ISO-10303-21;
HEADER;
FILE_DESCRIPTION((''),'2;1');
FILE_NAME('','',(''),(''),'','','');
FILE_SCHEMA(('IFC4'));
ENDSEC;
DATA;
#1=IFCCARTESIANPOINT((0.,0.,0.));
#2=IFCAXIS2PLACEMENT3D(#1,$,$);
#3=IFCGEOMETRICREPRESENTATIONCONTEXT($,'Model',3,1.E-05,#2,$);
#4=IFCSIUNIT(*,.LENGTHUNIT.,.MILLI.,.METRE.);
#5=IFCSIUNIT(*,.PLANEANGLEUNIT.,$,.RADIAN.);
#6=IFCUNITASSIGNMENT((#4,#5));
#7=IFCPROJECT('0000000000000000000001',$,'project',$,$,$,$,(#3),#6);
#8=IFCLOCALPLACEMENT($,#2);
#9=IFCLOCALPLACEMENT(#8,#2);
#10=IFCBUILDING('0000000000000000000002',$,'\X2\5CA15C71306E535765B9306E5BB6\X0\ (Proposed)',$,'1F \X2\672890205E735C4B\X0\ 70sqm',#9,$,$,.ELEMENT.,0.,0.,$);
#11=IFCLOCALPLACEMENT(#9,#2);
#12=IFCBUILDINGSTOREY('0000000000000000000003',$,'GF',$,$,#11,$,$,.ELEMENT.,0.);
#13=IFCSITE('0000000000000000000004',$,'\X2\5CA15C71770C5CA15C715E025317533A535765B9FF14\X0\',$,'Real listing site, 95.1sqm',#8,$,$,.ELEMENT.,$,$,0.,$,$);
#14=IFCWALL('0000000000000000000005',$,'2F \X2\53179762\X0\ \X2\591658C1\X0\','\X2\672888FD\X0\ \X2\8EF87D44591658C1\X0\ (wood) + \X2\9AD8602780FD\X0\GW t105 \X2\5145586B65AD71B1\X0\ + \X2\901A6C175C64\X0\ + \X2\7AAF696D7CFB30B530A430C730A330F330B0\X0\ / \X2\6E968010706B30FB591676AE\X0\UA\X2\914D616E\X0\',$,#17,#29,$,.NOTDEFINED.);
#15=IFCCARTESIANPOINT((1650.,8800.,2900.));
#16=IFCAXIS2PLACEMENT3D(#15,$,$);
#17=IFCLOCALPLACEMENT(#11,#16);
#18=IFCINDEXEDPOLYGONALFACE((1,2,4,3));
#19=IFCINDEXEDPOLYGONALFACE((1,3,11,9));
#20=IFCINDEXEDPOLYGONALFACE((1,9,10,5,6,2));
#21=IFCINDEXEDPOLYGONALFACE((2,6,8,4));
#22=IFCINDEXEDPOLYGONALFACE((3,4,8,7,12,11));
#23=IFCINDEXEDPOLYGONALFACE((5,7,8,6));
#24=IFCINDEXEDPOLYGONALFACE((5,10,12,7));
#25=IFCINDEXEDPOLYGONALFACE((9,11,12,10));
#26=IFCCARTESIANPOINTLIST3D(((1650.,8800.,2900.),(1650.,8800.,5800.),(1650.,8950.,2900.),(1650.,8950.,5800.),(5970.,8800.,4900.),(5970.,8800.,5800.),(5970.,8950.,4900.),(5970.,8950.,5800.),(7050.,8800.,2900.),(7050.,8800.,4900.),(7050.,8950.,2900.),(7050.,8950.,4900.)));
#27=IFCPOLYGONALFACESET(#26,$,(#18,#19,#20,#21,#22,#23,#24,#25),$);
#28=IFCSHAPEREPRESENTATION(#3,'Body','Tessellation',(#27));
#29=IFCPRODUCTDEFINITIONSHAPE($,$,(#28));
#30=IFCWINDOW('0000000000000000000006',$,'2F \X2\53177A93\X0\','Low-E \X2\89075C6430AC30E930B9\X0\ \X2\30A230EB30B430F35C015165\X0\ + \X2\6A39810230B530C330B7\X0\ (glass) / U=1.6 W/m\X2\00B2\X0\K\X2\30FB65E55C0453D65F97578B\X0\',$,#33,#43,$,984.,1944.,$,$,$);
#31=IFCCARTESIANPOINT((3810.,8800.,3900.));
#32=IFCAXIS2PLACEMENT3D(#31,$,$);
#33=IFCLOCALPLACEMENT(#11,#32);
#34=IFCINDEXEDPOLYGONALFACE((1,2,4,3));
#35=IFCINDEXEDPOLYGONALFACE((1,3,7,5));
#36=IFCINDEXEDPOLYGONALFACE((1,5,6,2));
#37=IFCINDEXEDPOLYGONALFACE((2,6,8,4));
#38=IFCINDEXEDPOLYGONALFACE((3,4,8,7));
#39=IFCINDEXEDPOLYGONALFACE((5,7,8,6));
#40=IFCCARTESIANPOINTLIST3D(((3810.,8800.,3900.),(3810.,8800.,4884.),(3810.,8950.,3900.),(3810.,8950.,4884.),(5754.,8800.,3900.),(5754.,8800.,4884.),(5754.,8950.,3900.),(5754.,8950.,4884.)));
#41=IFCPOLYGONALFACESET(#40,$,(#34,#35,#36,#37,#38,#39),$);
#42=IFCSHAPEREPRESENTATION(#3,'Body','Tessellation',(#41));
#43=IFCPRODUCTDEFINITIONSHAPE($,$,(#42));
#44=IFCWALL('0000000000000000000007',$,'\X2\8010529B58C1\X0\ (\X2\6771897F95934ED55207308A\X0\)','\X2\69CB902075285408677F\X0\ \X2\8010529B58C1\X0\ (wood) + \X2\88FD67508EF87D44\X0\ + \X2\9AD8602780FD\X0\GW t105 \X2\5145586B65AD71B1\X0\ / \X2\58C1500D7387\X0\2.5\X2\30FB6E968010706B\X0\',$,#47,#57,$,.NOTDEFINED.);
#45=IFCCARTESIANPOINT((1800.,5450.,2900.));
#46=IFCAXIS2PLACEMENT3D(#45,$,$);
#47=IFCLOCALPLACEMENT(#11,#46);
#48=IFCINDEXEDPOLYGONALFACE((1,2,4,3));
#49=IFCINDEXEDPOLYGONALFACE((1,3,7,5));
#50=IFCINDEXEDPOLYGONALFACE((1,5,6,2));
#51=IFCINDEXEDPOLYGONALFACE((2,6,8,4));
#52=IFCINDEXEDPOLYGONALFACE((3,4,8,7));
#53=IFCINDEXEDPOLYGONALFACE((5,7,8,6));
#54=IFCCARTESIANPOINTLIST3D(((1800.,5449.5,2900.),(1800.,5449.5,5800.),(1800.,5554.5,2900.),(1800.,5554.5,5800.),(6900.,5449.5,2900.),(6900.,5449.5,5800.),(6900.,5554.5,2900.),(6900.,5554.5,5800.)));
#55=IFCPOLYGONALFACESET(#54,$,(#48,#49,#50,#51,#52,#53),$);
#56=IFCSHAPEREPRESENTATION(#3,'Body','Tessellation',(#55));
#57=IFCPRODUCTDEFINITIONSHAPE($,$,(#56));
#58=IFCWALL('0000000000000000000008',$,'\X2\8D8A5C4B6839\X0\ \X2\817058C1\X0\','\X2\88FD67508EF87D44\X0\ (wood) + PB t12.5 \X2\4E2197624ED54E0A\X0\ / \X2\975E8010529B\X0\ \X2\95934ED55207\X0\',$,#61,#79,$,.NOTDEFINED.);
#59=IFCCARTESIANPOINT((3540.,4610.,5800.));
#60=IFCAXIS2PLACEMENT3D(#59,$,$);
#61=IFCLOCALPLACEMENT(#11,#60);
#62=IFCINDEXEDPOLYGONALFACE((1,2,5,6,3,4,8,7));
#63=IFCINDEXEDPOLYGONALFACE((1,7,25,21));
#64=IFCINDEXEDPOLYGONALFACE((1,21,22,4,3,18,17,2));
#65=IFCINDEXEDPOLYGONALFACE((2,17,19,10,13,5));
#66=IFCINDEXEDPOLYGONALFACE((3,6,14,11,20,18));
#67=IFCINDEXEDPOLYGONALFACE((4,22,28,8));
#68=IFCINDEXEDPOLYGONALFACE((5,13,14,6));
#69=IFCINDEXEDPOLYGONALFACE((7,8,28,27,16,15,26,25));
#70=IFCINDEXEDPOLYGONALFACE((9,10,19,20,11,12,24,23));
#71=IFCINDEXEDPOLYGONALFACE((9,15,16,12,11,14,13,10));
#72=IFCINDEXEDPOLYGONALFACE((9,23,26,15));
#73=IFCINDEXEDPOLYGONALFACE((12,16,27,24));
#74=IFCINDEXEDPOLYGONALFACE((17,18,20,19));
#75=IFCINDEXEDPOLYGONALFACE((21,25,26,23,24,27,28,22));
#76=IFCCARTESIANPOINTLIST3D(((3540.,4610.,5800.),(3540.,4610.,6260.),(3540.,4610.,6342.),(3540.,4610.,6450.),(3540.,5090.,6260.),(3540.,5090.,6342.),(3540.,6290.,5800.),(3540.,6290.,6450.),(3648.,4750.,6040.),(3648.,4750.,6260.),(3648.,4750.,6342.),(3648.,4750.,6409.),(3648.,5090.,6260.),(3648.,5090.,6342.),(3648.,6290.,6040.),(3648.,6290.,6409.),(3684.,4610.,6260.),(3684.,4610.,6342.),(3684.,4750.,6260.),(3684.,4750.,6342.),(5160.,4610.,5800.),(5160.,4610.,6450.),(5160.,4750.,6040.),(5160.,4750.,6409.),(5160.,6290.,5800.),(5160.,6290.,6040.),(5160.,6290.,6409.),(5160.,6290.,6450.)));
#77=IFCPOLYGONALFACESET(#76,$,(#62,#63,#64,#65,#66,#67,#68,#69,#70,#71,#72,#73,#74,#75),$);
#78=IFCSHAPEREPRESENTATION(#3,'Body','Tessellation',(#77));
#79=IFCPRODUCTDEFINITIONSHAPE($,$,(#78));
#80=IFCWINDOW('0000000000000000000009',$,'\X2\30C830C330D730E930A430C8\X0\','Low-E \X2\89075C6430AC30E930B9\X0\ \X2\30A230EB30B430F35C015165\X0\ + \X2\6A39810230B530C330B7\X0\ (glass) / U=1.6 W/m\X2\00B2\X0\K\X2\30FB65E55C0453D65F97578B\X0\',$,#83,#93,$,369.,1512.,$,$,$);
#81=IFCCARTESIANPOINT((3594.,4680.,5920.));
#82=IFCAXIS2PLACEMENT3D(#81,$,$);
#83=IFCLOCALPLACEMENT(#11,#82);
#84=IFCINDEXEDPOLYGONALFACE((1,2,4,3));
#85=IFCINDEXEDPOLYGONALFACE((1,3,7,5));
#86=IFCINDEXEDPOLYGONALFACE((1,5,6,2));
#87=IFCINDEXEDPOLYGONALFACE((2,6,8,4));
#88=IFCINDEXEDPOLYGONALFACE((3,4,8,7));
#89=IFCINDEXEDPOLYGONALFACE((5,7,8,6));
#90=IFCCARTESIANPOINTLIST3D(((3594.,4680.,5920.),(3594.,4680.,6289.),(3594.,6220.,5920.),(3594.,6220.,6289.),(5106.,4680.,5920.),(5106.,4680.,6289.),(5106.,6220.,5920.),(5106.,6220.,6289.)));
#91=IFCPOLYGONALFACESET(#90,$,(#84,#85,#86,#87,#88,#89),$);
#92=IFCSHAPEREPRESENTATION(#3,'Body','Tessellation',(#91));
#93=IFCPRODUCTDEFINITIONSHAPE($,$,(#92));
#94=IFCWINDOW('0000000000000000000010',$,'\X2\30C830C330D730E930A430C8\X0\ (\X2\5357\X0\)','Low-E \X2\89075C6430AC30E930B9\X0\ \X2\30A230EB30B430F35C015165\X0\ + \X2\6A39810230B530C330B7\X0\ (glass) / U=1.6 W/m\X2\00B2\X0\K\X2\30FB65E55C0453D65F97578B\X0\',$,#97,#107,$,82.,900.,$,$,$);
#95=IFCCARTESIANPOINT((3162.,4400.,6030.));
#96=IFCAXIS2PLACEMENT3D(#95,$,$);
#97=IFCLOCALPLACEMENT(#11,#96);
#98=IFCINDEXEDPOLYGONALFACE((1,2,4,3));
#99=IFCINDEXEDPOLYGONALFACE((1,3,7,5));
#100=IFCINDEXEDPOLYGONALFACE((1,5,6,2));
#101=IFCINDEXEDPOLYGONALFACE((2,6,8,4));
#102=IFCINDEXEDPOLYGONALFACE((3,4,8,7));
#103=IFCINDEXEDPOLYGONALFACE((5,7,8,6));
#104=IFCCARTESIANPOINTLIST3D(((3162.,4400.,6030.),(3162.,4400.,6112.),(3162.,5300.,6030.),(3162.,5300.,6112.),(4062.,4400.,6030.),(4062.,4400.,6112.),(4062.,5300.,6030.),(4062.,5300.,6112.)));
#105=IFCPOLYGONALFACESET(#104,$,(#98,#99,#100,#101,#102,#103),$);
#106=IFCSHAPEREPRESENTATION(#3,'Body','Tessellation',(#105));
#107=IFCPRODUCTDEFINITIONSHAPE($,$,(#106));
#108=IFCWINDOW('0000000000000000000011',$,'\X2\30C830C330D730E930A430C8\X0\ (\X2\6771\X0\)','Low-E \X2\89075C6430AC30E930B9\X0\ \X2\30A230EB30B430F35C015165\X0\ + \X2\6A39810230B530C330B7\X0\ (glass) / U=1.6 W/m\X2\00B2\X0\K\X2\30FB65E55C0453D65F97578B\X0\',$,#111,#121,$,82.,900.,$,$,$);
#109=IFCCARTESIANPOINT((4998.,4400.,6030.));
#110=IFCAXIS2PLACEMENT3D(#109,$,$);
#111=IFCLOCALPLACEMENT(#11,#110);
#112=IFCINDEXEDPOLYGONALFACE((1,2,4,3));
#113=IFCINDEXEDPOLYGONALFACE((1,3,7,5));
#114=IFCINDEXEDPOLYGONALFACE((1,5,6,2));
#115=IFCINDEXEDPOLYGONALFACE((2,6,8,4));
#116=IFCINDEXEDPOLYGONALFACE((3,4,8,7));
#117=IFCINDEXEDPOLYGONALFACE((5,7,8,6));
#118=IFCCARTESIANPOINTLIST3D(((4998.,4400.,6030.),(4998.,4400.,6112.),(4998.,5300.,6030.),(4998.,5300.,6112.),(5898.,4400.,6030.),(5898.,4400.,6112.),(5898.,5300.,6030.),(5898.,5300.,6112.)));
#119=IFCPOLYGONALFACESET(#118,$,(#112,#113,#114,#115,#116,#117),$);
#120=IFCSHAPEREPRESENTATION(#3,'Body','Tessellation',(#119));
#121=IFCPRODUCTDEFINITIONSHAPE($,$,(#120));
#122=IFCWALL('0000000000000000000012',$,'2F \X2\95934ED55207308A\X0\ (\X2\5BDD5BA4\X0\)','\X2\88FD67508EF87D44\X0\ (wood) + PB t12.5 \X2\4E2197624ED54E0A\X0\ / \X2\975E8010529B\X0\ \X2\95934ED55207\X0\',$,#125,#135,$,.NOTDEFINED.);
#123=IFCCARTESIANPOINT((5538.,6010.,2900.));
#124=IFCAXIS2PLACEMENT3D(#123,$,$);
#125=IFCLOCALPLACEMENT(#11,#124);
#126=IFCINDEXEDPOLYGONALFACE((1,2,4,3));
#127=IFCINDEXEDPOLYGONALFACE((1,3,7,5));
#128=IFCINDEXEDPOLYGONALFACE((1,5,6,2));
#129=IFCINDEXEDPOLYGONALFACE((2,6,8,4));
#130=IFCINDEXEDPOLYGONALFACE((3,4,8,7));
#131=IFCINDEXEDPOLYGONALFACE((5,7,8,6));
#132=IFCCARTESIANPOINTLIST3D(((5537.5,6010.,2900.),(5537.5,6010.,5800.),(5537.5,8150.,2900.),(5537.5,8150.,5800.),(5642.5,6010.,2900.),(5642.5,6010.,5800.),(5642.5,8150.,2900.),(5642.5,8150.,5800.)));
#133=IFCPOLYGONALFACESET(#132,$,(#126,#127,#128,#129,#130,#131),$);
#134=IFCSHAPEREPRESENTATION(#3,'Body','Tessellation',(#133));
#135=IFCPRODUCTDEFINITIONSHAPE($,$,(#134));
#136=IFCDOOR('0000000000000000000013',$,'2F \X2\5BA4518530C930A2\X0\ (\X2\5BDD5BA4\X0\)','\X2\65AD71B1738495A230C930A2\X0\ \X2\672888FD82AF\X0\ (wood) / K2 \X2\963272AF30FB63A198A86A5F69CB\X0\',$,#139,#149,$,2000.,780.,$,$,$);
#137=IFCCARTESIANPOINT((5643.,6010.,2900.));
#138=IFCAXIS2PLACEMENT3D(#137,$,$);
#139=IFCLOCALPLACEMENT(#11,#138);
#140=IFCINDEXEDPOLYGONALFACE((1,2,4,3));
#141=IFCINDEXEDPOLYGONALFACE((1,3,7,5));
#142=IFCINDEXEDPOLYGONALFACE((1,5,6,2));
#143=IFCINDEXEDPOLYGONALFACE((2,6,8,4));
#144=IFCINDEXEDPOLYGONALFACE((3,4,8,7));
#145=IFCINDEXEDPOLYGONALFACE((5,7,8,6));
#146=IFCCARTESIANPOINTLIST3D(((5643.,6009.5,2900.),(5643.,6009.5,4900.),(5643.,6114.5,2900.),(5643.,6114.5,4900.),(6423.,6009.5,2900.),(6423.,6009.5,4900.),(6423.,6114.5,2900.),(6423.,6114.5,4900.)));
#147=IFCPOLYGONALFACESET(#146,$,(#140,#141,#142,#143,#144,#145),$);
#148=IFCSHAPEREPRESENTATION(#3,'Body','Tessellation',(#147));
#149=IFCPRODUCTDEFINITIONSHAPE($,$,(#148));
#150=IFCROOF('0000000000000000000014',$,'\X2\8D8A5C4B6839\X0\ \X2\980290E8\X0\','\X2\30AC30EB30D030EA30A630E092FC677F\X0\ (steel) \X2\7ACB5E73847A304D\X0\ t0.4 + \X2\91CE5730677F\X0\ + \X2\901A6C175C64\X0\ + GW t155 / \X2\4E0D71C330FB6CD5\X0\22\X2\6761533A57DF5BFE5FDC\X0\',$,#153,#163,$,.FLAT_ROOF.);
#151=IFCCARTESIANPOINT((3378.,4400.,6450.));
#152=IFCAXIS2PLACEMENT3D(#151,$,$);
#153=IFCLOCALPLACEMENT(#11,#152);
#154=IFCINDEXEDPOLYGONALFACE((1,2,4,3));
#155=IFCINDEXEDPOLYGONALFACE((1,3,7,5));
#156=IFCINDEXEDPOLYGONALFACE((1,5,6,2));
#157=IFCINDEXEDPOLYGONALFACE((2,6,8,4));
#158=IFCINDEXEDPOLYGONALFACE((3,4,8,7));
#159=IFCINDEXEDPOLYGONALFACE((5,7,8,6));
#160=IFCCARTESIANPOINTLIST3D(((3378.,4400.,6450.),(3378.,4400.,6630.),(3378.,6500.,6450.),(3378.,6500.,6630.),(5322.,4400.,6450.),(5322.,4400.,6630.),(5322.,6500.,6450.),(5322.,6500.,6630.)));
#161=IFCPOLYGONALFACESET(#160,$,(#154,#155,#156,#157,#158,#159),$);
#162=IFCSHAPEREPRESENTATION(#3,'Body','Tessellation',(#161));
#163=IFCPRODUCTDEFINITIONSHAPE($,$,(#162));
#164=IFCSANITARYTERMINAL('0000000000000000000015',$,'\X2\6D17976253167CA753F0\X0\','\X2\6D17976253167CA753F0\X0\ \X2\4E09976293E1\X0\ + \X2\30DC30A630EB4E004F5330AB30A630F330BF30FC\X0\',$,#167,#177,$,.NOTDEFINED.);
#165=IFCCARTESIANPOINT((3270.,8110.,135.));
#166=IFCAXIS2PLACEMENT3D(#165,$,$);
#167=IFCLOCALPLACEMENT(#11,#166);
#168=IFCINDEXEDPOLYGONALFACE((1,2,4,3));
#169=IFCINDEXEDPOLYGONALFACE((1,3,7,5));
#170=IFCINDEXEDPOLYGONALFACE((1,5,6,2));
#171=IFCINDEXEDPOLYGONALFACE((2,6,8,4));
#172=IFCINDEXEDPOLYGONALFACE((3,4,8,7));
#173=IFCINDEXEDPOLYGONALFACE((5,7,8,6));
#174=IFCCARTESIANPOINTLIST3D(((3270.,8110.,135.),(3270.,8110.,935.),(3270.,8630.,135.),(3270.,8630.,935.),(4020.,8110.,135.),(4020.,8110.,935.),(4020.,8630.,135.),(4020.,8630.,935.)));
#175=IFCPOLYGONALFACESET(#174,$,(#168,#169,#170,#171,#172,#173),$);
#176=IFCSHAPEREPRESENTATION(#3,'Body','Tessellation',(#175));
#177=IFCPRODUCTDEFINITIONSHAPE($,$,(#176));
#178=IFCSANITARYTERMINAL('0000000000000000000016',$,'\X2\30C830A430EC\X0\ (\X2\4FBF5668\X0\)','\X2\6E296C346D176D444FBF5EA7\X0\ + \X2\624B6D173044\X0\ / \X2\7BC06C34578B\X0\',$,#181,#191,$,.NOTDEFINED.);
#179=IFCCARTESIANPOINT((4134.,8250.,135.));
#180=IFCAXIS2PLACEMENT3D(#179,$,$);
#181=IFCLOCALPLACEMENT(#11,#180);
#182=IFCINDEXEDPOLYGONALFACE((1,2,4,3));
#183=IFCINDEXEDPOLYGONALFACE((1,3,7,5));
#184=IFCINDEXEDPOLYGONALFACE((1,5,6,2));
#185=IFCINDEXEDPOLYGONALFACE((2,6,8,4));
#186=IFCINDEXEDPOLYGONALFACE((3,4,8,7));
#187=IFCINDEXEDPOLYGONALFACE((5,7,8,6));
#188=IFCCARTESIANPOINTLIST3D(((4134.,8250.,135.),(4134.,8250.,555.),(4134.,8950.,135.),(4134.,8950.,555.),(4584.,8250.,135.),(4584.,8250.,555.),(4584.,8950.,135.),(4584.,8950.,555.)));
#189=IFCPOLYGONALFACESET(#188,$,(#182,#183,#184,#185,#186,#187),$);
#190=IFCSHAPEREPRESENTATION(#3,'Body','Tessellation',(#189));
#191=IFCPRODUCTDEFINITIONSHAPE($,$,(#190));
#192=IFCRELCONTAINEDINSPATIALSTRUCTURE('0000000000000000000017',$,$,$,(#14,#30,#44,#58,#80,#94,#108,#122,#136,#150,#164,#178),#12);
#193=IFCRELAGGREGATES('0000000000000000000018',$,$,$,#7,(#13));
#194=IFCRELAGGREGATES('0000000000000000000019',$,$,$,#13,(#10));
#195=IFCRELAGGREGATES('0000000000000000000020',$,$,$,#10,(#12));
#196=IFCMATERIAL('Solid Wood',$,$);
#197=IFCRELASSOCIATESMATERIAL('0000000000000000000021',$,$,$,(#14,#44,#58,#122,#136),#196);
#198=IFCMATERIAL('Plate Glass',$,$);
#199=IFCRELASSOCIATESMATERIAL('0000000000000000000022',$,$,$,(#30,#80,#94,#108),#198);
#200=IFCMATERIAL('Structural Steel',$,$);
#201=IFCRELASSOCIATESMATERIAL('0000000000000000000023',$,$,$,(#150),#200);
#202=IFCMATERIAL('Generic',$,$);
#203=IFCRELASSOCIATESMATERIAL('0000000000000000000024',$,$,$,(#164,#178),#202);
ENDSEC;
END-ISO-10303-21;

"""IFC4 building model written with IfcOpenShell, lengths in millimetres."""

from ifc_helpers import new_model, si_unit, frame, frame_2d, origin, place, context, project, spatial, rectangle, extrude, material, element, fill, save


model = new_model("IFC4")

# Units and contexts
model_context = context("Model", 3, precision=1e-05, world=origin())
ifc_project = project(units=[si_unit("LENGTHUNIT", "METRE", prefix="MILLI"), si_unit("PLANEANGLEUNIT", "RADIAN")], contexts=[model_context])

# Site, building, storey
site_placement = place(None, origin())
site = spatial("IfcSite", under=ifc_project, at=site_placement, Name="岡山県岡山市北区南方４", ObjectType="Real listing site, 95.1sqm", CompositionType="ELEMENT", RefElevation=0.0)
building_placement = place(site_placement, origin())
building = spatial("IfcBuilding", under=site, at=building_placement, Name="岡山の南方の家 (Proposed)", ObjectType="1F 木造平屋 70sqm", CompositionType="ELEMENT", ElevationOfRefHeight=0.0, ElevationOfTerrain=0.0)
storey_placement = place(building_placement, origin())
storey = spatial("IfcBuildingStorey", under=building, at=storey_placement, Name="GF", CompositionType="ELEMENT", Elevation=0.0)

# Wall, opening, window
ifc_material_1 = material(Name="Solid Wood")
wall_1_placement = place(storey_placement, frame((1650.0, 8800.0, 2900.0)))
wall_1 = element("IfcWall", 1, at=wall_1_placement, inside=storey, material=ifc_material_1, Name="2F 北面 外壁", Description="木製 軸組外壁 (wood) + 高性能GW t105 充填断熱 + 通気層 + 窯業系サイディング / 準耐火・外皮UA配慮", PredefinedType="NOTDEFINED", context=model_context, shape_type="SweptSolid", body=[
    extrude(rectangle(XDim=5400.0, YDim=150.0, at=frame_2d((2700.0, 75.0))), frame((1650.0, 8800.0, 2900.0)), (0.0, 0.0, 1.0), 2900.0),
])
opening_1_placement = place(storey_placement, frame((3810.0, 8800.0, 3900.0)))
opening_1 = element("IfcOpeningElement", 2, at=opening_1_placement, cuts=wall_1, PredefinedType="NOTDEFINED", context=model_context, shape_type="SweptSolid", body=[
    extrude(rectangle(XDim=1944.0, YDim=150.0, at=frame_2d((972.0, 75.0))), frame((3810.0, 8800.0, 3900.0)), (0.0, 0.0, 1.0), 984.0),
])
ifc_material_2 = material(Name="Plate Glass")
window_1_placement = place(storey_placement, frame((3810.0, 8800.0, 3900.0)))
window_1 = element("IfcWindow", 3, at=window_1_placement, inside=storey, material=ifc_material_2, Name="2F 北窓", Description="Low-E 複層ガラス アルゴン封入 + 樹脂サッシ (glass) / U=1.6 W/m²K・日射取得型", OverallHeight=984.0, OverallWidth=1944.0, context=model_context, shape_type="SweptSolid", body=[
    extrude(rectangle(XDim=1944.0, YDim=150.0, at=frame_2d((972.0, 75.0))), frame((3810.0, 8800.0, 3900.0)), (0.0, 0.0, 1.0), 984.0),
])
fill(opening_1, window_1)

# Wall
wall_2_placement = place(storey_placement, frame((1800.0, 5450.0, 2900.0)))
element("IfcWall", 4, at=wall_2_placement, inside=storey, material=ifc_material_1, Name="耐力壁 (東西間仕切り)", Description="構造用合板 耐力壁 (wood) + 製材軸組 + 高性能GW t105 充填断熱 / 壁倍率2.5・準耐火", PredefinedType="NOTDEFINED", context=model_context, shape_type="SweptSolid", body=[
    extrude(rectangle(XDim=5100.0, YDim=105.0, at=frame_2d((2550.0, 52.0))), frame((1800.0, 5450.0, 2900.0)), (0.0, 0.0, 1.0), 2900.0),
])

# Wall, openings, windows
wall_3_placement = place(storey_placement, frame((3540.0, 4610.0, 5800.0)))
wall_3 = element("IfcWall", 5, at=wall_3_placement, inside=storey, material=ifc_material_1, Name="越屋根 腰壁", Description="製材軸組 (wood) + PB t12.5 両面仕上 / 非耐力 間仕切", PredefinedType="NOTDEFINED", context=model_context, shape_type="SweptSolid", body=[
    extrude(rectangle(XDim=1620.0, YDim=1680.0, at=frame_2d((810.0, 840.0))), frame((3540.0, 4610.0, 5800.0)), (0.0, 0.0, 1.0), 650.0),
])
opening_2_placement = place(storey_placement, frame((3594.0, 4680.0, 5920.0)))
opening_2 = element("IfcOpeningElement", 6, at=opening_2_placement, cuts=wall_3, PredefinedType="NOTDEFINED", context=model_context, shape_type="SweptSolid", body=[
    extrude(rectangle(XDim=1512.0, YDim=1540.0, at=frame_2d((756.0, 770.0))), frame((3594.0, 4680.0, 5920.0)), (0.0, 0.0, 1.0), 369.0),
])
opening_3_placement = place(storey_placement, frame((3162.0, 4400.0, 6030.0)))
opening_3 = element("IfcOpeningElement", 7, at=opening_3_placement, cuts=wall_3, PredefinedType="NOTDEFINED", context=model_context, shape_type="SweptSolid", body=[
    extrude(rectangle(XDim=900.0, YDim=900.0, at=frame_2d((450.0, 450.0))), frame((3162.0, 4400.0, 6030.0)), (0.0, 0.0, 1.0), 82.0),
])
opening_4_placement = place(storey_placement, frame((4998.0, 4400.0, 6030.0)))
opening_4 = element("IfcOpeningElement", 8, at=opening_4_placement, cuts=wall_3, PredefinedType="NOTDEFINED", context=model_context, shape_type="SweptSolid", body=[
    extrude(rectangle(XDim=900.0, YDim=900.0, at=frame_2d((450.0, 450.0))), frame((4998.0, 4400.0, 6030.0)), (0.0, 0.0, 1.0), 82.0),
])
window_2_placement = place(storey_placement, frame((3594.0, 4680.0, 5920.0)))
window_2 = element("IfcWindow", 9, at=window_2_placement, inside=storey, material=ifc_material_2, Name="トップライト", Description="Low-E 複層ガラス アルゴン封入 + 樹脂サッシ (glass) / U=1.6 W/m²K・日射取得型", OverallHeight=369.0, OverallWidth=1512.0, context=model_context, shape_type="SweptSolid", body=[
    extrude(rectangle(XDim=1512.0, YDim=1540.0, at=frame_2d((756.0, 770.0))), frame((3594.0, 4680.0, 5920.0)), (0.0, 0.0, 1.0), 369.0),
])
fill(opening_2, window_2)
window_3_placement = place(storey_placement, frame((3162.0, 4400.0, 6030.0)))
window_3 = element("IfcWindow", 10, at=window_3_placement, inside=storey, material=ifc_material_2, Name="トップライト (南)", Description="Low-E 複層ガラス アルゴン封入 + 樹脂サッシ (glass) / U=1.6 W/m²K・日射取得型", OverallHeight=82.0, OverallWidth=900.0, context=model_context, shape_type="SweptSolid", body=[
    extrude(rectangle(XDim=900.0, YDim=900.0, at=frame_2d((450.0, 450.0))), frame((3162.0, 4400.0, 6030.0)), (0.0, 0.0, 1.0), 82.0),
])
fill(opening_3, window_3)
window_4_placement = place(storey_placement, frame((4998.0, 4400.0, 6030.0)))
window_4 = element("IfcWindow", 11, at=window_4_placement, inside=storey, material=ifc_material_2, Name="トップライト (東)", Description="Low-E 複層ガラス アルゴン封入 + 樹脂サッシ (glass) / U=1.6 W/m²K・日射取得型", OverallHeight=82.0, OverallWidth=900.0, context=model_context, shape_type="SweptSolid", body=[
    extrude(rectangle(XDim=900.0, YDim=900.0, at=frame_2d((450.0, 450.0))), frame((4998.0, 4400.0, 6030.0)), (0.0, 0.0, 1.0), 82.0),
])
fill(opening_4, window_4)

# Wall
wall_4_placement = place(storey_placement, frame((5538.0, 6010.0, 2900.0)))
element("IfcWall", 12, at=wall_4_placement, inside=storey, material=ifc_material_1, Name="2F 間仕切り (寝室)", Description="製材軸組 (wood) + PB t12.5 両面仕上 / 非耐力 間仕切", PredefinedType="NOTDEFINED", context=model_context, shape_type="SweptSolid", body=[
    extrude(rectangle(XDim=105.0, YDim=2140.0, at=frame_2d((52.0, 1070.0))), frame((5538.0, 6010.0, 2900.0)), (0.0, 0.0, 1.0), 2900.0),
])

# Door
door_placement = place(storey_placement, frame((5643.0, 6010.0, 2900.0)))
element("IfcDoor", 13, at=door_placement, inside=storey, material=ifc_material_1, Name="2F 室内ドア (寝室)", Description="断熱玄関ドア 木製芯 (wood) / K2 防犯・採風機構", OverallHeight=2000.0, OverallWidth=780.0, context=model_context, shape_type="SweptSolid", body=[
    extrude(rectangle(XDim=780.0, YDim=105.0, at=frame_2d((390.0, 52.0))), frame((5643.0, 6010.0, 2900.0)), (0.0, 0.0, 1.0), 2000.0),
])

# Roof
ifc_material_3 = material(Name="Structural Steel")
roof_placement = place(storey_placement, frame((3378.0, 4400.0, 6450.0)))
element("IfcRoof", 14, at=roof_placement, inside=storey, material=ifc_material_3, Name="越屋根 頂部", Description="ガルバリウム鋼板 (steel) 立平葺き t0.4 + 野地板 + 通気層 + GW t155 / 不燃・法22条区域対応", PredefinedType="FLAT_ROOF", context=model_context, shape_type="SweptSolid", body=[
    extrude(rectangle(XDim=1944.0, YDim=2100.0, at=frame_2d((972.0, 1050.0))), frame((3378.0, 4400.0, 6450.0)), (0.0, 0.0, 1.0), 180.0),
])

# Sanitary terminals
ifc_material_4 = material(Name="Generic")
sanitary_terminal_1_placement = place(storey_placement, frame((3270.0, 8110.0, 135.0)))
element("IfcSanitaryTerminal", 15, at=sanitary_terminal_1_placement, inside=storey, material=ifc_material_4, Name="洗面化粧台", Description="洗面化粧台 三面鏡 + ボウル一体カウンター", PredefinedType="NOTDEFINED", context=model_context, shape_type="SweptSolid", body=[
    extrude(rectangle(XDim=750.0, YDim=520.0, at=frame_2d((375.0, 260.0))), frame((3270.0, 8110.0, 135.0)), (0.0, 0.0, 1.0), 800.0),
])
sanitary_terminal_2_placement = place(storey_placement, frame((4134.0, 8250.0, 135.0)))
element("IfcSanitaryTerminal", 16, at=sanitary_terminal_2_placement, inside=storey, material=ifc_material_4, Name="トイレ (便器)", Description="温水洗浄便座 + 手洗い / 節水型", PredefinedType="NOTDEFINED", context=model_context, shape_type="SweptSolid", body=[
    extrude(rectangle(XDim=450.0, YDim=700.0, at=frame_2d((225.0, 350.0))), frame((4134.0, 8250.0, 135.0)), (0.0, 0.0, 1.0), 420.0),
])

save(model, "model.ifc")
